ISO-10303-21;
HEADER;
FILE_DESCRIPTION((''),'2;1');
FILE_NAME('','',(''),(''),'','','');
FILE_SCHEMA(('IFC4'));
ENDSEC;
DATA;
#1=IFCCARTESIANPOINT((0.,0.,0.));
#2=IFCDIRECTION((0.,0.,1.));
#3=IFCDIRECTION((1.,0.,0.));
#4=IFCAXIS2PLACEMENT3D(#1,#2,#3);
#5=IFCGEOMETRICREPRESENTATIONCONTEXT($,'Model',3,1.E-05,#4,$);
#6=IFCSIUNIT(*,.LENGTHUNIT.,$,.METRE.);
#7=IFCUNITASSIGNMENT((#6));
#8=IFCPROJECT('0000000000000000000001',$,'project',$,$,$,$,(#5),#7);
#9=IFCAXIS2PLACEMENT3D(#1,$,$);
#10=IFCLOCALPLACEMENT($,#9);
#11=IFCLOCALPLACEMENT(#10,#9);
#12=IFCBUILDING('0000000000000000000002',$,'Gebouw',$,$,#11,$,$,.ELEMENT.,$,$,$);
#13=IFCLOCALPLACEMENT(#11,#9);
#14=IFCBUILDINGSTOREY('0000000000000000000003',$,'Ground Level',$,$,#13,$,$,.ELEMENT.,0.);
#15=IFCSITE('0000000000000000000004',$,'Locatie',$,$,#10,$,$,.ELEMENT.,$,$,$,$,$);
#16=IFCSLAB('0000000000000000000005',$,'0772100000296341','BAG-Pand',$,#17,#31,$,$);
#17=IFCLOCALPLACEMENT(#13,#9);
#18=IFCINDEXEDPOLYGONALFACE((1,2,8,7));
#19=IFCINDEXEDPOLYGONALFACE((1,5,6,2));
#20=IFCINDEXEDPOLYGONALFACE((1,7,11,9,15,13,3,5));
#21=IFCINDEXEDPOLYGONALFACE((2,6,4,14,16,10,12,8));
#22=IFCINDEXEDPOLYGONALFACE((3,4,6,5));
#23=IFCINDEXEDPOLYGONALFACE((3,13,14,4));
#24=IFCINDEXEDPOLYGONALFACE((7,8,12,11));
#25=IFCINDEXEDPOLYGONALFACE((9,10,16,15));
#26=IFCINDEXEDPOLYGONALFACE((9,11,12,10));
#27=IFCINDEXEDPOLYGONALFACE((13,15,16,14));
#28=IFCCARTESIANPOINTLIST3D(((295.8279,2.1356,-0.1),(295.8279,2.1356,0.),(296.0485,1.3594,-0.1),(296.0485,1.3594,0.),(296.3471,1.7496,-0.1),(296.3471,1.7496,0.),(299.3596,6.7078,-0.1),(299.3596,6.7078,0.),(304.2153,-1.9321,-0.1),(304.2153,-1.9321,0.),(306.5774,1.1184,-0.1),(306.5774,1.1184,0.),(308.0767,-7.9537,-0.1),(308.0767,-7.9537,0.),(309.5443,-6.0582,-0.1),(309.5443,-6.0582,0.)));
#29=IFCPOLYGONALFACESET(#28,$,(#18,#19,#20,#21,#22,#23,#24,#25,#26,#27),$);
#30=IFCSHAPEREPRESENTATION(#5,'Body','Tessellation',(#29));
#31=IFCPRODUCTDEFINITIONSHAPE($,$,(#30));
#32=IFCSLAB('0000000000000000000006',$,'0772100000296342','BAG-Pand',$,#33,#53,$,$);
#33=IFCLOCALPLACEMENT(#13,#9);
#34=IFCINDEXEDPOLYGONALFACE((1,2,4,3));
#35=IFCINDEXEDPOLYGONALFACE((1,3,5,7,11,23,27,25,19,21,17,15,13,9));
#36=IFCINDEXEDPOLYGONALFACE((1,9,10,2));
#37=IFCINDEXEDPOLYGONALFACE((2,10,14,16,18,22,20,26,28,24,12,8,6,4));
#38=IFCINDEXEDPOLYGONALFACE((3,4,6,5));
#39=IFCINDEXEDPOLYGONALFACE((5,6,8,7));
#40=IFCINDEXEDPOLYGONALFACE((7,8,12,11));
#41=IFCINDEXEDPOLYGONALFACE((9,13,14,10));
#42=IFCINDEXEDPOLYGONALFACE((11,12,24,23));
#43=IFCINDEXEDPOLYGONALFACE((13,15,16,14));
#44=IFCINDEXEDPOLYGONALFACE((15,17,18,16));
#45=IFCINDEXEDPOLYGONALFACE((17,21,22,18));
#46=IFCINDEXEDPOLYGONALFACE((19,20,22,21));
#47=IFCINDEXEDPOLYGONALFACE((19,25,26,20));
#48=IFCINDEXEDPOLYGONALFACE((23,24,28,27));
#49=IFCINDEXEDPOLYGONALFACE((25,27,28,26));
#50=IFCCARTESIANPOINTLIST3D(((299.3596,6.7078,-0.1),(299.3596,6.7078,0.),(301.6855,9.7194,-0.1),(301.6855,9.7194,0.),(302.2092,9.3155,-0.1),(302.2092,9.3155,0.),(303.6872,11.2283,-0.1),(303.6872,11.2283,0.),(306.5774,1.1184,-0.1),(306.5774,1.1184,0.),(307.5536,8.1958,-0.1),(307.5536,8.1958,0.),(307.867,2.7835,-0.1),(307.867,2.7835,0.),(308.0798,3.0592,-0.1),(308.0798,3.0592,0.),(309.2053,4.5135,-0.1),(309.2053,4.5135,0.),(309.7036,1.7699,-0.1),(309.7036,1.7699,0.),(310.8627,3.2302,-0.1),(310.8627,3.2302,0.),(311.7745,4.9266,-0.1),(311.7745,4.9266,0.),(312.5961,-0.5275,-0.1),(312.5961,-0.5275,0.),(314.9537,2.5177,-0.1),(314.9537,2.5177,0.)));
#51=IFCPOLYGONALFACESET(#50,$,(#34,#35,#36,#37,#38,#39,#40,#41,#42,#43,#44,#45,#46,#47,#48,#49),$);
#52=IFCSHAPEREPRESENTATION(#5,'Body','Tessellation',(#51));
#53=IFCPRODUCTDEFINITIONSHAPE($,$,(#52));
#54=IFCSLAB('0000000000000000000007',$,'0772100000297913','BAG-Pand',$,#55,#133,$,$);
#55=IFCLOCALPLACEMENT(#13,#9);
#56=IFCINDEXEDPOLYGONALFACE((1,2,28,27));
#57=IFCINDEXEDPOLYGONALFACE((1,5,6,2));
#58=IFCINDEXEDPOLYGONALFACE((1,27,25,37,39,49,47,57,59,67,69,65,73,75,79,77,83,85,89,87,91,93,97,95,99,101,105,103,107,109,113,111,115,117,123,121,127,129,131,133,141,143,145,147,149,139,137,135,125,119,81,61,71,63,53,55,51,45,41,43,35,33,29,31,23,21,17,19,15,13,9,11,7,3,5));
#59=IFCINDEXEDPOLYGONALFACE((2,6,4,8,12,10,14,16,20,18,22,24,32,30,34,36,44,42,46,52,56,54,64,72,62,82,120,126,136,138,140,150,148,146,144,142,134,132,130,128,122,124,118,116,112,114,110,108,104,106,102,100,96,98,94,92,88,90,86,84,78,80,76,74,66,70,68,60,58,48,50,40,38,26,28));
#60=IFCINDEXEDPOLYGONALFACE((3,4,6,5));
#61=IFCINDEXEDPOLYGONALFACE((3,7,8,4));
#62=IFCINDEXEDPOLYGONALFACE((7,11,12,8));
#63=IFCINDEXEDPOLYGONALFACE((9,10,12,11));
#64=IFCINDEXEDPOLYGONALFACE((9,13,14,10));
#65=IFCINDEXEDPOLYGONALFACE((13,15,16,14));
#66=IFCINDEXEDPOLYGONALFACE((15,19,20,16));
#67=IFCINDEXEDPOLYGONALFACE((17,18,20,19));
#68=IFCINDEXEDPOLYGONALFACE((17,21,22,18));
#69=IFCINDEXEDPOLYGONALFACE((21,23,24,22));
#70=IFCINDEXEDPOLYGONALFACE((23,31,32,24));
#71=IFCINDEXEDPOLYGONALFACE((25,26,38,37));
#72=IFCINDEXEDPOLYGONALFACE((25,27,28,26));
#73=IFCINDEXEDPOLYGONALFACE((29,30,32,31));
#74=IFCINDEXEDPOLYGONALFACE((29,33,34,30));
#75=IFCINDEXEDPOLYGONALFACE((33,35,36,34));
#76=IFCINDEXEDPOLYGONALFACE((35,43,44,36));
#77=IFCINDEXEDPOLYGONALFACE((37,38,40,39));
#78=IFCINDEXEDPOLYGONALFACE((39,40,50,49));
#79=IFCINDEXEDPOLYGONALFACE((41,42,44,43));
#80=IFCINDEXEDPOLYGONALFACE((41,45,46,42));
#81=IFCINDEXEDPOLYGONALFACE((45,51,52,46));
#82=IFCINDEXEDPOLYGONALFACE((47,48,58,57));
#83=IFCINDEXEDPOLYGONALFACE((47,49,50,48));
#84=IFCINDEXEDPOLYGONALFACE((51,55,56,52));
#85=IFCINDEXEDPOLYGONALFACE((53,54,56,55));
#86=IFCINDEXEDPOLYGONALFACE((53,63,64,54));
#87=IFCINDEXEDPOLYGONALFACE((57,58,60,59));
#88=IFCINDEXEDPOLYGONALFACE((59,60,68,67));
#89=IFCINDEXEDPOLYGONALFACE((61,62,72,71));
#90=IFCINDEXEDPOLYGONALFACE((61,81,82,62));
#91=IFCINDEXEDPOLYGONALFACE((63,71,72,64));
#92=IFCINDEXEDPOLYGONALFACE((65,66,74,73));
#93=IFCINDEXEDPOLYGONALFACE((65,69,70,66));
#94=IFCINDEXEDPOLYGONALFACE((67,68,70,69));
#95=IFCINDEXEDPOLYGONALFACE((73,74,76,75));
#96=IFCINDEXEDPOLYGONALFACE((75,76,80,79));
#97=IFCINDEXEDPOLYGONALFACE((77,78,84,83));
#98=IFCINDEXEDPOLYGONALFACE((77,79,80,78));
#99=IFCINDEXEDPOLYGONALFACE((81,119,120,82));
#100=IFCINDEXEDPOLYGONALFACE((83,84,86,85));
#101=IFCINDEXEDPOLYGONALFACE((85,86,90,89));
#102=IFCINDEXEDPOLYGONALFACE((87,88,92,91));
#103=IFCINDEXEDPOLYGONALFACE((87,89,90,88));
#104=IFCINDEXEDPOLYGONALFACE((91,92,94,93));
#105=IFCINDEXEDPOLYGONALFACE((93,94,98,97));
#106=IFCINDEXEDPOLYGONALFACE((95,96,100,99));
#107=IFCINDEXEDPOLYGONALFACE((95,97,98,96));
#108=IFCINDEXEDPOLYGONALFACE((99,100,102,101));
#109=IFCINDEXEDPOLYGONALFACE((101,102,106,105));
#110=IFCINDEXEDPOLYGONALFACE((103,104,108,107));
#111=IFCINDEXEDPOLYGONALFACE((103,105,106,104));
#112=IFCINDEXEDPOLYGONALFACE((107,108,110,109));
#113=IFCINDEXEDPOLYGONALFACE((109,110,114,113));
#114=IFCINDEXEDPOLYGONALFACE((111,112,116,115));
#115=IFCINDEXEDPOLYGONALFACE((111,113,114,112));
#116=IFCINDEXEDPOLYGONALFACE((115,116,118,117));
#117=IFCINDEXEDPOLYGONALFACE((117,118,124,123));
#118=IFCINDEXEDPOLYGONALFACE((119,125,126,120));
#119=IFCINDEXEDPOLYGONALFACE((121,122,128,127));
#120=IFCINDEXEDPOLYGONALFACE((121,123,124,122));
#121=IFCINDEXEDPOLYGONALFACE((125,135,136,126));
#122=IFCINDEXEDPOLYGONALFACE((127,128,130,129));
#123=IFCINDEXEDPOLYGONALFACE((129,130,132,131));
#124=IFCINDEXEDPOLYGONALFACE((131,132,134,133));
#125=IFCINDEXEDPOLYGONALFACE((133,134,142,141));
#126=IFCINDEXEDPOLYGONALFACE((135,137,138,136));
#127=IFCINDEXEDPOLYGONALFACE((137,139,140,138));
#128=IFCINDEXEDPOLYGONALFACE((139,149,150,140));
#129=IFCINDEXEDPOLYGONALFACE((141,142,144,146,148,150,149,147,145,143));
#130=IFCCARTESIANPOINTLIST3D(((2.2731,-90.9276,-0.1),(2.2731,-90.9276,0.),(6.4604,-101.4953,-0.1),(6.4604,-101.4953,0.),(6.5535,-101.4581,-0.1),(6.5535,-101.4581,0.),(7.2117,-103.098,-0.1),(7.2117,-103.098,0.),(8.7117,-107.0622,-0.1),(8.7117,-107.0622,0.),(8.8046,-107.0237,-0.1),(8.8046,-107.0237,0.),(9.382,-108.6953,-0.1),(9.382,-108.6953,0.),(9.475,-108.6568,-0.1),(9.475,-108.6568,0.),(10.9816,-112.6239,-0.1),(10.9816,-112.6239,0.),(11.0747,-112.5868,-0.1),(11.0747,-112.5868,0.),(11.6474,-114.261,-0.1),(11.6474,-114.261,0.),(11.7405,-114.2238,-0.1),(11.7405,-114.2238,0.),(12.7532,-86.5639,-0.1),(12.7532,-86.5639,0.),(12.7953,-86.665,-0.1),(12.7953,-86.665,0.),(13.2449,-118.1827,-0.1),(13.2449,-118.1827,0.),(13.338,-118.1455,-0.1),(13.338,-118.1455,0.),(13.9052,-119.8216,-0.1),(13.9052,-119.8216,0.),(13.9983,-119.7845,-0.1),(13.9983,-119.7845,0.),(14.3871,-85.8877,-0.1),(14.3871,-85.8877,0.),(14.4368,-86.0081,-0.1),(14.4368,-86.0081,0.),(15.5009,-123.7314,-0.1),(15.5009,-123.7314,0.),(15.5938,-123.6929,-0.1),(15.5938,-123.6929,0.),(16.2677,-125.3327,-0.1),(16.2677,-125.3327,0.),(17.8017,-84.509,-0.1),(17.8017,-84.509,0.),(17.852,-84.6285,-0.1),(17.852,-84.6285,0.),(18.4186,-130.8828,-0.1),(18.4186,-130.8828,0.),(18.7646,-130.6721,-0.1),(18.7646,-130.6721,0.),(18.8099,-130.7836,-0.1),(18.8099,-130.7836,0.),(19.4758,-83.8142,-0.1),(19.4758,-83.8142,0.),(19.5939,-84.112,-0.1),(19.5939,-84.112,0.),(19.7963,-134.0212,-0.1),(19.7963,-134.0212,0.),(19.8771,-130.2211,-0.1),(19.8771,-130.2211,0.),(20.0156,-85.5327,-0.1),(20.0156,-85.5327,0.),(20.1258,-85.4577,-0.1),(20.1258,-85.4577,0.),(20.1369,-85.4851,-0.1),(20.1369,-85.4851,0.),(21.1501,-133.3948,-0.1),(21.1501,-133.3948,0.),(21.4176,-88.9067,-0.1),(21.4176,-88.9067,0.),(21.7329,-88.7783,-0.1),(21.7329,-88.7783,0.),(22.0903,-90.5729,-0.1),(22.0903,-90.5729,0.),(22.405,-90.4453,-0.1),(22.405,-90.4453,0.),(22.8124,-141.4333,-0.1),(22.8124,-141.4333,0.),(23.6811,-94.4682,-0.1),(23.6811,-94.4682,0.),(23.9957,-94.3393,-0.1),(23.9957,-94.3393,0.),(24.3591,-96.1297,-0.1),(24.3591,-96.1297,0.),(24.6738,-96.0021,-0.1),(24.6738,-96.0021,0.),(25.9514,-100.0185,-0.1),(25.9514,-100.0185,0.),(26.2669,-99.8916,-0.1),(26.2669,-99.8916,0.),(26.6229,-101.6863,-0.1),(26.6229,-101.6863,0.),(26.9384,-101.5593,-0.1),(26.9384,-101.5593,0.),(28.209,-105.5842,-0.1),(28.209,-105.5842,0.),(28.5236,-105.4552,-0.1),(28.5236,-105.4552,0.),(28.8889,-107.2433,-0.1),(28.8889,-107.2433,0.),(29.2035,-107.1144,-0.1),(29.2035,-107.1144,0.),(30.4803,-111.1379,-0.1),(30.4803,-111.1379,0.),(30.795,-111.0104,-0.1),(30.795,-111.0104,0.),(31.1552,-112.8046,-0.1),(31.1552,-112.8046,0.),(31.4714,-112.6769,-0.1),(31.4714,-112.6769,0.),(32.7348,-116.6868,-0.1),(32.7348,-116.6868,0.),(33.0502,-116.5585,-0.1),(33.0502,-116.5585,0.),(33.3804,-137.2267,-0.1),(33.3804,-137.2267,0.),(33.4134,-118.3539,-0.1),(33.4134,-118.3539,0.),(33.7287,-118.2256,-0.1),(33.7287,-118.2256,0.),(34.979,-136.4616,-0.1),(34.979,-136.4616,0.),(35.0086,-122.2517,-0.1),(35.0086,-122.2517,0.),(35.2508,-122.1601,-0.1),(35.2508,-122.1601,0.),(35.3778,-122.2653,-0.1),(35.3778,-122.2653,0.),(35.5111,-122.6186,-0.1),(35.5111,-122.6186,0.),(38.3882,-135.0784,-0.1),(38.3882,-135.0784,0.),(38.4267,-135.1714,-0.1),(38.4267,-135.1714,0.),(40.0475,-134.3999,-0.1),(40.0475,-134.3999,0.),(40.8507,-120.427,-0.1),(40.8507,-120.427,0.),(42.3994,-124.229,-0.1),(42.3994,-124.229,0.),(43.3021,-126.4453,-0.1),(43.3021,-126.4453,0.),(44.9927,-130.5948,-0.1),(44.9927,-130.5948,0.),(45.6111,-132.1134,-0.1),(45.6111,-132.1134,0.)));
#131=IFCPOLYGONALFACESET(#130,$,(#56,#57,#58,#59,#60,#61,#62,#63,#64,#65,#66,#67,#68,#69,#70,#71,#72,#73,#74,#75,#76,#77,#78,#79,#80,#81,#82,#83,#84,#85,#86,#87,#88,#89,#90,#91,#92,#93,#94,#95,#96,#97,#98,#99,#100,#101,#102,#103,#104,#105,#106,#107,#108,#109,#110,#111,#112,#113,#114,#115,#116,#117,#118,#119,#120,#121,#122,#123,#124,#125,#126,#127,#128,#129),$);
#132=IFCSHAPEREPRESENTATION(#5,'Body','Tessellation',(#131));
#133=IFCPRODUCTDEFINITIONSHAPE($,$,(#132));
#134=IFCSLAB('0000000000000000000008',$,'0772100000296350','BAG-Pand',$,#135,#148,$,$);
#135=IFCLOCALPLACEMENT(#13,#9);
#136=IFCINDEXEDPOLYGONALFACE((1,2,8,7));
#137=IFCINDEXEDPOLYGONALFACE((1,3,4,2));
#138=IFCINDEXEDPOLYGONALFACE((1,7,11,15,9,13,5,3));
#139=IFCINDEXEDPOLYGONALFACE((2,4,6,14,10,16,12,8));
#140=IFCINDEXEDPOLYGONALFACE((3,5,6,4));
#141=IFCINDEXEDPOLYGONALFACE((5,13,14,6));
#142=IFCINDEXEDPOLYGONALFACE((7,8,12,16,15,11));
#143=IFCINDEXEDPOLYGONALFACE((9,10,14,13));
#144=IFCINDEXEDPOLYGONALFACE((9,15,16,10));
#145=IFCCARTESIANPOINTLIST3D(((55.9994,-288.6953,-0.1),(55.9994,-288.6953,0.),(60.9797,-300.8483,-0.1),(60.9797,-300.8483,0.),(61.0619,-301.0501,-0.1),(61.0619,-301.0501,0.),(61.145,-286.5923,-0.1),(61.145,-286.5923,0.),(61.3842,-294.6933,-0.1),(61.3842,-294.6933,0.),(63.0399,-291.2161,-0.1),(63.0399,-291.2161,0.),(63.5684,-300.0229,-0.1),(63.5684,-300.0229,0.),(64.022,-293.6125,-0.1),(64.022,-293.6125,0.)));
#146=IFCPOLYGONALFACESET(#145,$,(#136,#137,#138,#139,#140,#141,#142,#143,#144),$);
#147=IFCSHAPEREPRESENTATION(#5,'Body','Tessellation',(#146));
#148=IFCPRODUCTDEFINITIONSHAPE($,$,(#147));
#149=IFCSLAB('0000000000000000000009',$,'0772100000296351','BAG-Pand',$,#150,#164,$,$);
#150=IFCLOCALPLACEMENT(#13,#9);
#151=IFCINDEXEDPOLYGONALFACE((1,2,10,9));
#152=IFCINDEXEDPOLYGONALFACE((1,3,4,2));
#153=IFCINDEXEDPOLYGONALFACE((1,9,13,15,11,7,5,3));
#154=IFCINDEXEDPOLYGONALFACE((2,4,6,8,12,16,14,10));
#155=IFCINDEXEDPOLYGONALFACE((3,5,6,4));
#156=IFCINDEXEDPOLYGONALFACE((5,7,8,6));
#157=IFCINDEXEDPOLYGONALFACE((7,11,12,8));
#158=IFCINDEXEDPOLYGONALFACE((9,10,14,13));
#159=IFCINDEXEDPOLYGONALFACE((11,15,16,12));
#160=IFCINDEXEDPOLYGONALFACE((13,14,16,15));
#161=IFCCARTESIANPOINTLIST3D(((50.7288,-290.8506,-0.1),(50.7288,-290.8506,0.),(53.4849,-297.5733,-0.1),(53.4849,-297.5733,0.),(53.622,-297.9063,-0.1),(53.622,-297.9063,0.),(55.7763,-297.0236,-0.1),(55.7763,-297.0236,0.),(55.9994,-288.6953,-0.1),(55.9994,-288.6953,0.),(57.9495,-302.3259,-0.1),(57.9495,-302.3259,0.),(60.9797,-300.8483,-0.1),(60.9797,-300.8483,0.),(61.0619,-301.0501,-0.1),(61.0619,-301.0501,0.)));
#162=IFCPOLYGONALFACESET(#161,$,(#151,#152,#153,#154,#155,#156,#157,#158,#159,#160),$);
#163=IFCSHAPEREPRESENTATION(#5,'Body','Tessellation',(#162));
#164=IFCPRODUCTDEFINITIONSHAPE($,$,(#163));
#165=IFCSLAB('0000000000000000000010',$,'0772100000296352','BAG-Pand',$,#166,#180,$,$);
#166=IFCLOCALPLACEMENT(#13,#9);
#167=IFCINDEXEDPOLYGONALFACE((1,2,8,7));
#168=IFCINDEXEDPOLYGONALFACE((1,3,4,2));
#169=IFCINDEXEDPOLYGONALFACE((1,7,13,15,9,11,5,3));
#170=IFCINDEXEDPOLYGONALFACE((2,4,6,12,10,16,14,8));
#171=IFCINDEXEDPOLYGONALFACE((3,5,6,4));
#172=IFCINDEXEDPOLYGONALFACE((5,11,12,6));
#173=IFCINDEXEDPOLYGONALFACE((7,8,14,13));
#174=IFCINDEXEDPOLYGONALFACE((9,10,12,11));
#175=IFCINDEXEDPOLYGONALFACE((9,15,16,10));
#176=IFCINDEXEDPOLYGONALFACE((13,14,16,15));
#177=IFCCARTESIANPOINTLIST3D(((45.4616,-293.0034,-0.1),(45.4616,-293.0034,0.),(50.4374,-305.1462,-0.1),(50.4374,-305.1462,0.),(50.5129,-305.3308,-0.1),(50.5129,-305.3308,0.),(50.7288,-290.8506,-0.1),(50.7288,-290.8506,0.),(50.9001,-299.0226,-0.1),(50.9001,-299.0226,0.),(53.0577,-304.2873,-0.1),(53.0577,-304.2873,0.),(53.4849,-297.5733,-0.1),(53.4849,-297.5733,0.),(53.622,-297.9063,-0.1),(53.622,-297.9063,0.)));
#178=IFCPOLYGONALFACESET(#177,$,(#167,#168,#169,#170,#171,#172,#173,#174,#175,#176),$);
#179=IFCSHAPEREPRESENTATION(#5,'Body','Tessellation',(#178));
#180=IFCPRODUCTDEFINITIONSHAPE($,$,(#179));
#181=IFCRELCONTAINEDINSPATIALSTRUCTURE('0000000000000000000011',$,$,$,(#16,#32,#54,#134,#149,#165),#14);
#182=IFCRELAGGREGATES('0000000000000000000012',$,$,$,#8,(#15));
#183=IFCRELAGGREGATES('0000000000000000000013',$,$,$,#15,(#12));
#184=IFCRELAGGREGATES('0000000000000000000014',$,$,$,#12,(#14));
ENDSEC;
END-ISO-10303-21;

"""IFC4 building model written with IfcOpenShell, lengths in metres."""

from ifc_helpers import new_model, si_unit, frame, origin, origin_with_axes, place, context, project, spatial, polyline, outline, extrude, element, save


model = new_model("IFC4")

# Units and contexts
model_context = context("Model", 3, precision=1e-05, world=origin_with_axes())
ifc_project = project(units=[si_unit("LENGTHUNIT", "METRE")], contexts=[model_context])

# Site, building, storey
site_placement = place(None, origin())
site = spatial("IfcSite", under=ifc_project, at=site_placement, Name="Locatie", CompositionType="ELEMENT")
building_placement = place(site_placement, origin())
building = spatial("IfcBuilding", under=site, at=building_placement, Name="Gebouw", CompositionType="ELEMENT")
storey_placement = place(building_placement, origin())
storey = spatial("IfcBuildingStorey", under=building, at=storey_placement, Name="Ground Level", CompositionType="ELEMENT", Elevation=0.0)

# Slabs
slab_1_placement = place(storey_placement, origin())
element("IfcSlab", 1, at=slab_1_placement, inside=storey, Name="0772100000296341", Description="BAG-Pand", context=model_context, shape_type="SweptSolid", body=[
    extrude(outline(polyline([(296.3471, 1.7496), (295.8279, 2.1356), (299.3596, 6.7078), (306.5774, 1.1184), (304.2153, -1.9321), (309.5443, -6.0582), (308.0767, -7.9537), (296.0485, 1.3594), (296.3471, 1.7496)])), frame((0.0, 0.0, -0.1), z_axis=(0.0, 0.0, 1.0), x_axis=(1.0, 0.0, 0.0)), (0.0, 0.0, 1.0), 0.1),
])
slab_2_placement = place(storey_placement, origin())
element("IfcSlab", 2, at=slab_2_placement, inside=storey, Name="0772100000296342", Description="BAG-Pand", context=model_context, shape_type="SweptSolid", body=[
    extrude(outline(polyline([(301.6855, 9.7194), (302.2092, 9.3155), (303.6872, 11.2283), (307.5536, 8.1958), (311.7745, 4.9266), (314.9537, 2.5177), (312.5961, -0.5275), (309.7036, 1.7699), (310.8627, 3.2302), (309.2053, 4.5135), (308.0798, 3.0592), (307.867, 2.7835), (306.5774, 1.1184), (299.3596, 6.7078), (301.6855, 9.7194)])), frame((0.0, 0.0, -0.1), z_axis=(0.0, 0.0, 1.0), x_axis=(1.0, 0.0, 0.0)), (0.0, 0.0, 1.0), 0.1),
])
slab_3_placement = place(storey_placement, origin())
element("IfcSlab", 3, at=slab_3_placement, inside=storey, Name="0772100000297913", Description="BAG-Pand", context=model_context, shape_type="SweptSolid", body=[
    extrude(outline(polyline([(19.7963, -134.0212), (21.1501, -133.3948), (19.8771, -130.2211), (18.7646, -130.6721), (18.8099, -130.7836), (18.4186, -130.8828), (16.2677, -125.3327), (15.5009, -123.7314), (15.5938, -123.6929), (13.9983, -119.7845), (13.9052, -119.8216), (13.2449, -118.1827), (13.338, -118.1455), (11.7405, -114.2238), (11.6474, -114.261), (10.9816, -112.6239), (11.0747, -112.5868), (9.475, -108.6568), (9.382, -108.6953), (8.7117, -107.0622), (8.8046, -107.0237), (7.2117, -103.098), (6.4604, -101.4953), (6.5535, -101.4581), (2.2731, -90.9276), (12.7953, -86.665), (12.7532, -86.5639), (14.3871, -85.8877), (14.4368, -86.0081), (17.852, -84.6285), (17.8017, -84.509), (19.4758, -83.8142), (19.5939, -84.112), (20.1258, -85.4577), (20.1369, -85.4851), (20.0156, -85.5327), (21.4176, -88.9067), (21.7329, -88.7783), (22.405, -90.4453), (22.0903, -90.5729), (23.6811, -94.4682), (23.9957, -94.3393), (24.6738, -96.0021), (24.3591, -96.1297), (25.9514, -100.0185), (26.2669, -99.8916), (26.9384, -101.5593), (26.6229, -101.6863), (28.209, -105.5842), (28.5236, -105.4552), (29.2035, -107.1144), (28.8889, -107.2433), (30.4803, -111.1379), (30.795, -111.0104), (31.4714, -112.6769), (31.1552, -112.8046), (32.7348, -116.6868), (33.0502, -116.5585), (33.7287, -118.2256), (33.4134, -118.3539), (35.0086, -122.2517), (35.2508, -122.1601), (35.3778, -122.2653), (35.5111, -122.6186), (40.8507, -120.427), (42.3994, -124.229), (43.3021, -126.4453), (44.9927, -130.5948), (45.6111, -132.1134), (40.0475, -134.3999), (38.4267, -135.1714), (38.3882, -135.0784), (34.979, -136.4616), (33.3804, -137.2267), (22.8124, -141.4333), (19.7963, -134.0212)])), frame((0.0, 0.0, -0.1), z_axis=(0.0, 0.0, 1.0), x_axis=(1.0, 0.0, 0.0)), (0.0, 0.0, 1.0), 0.1),
])
slab_4_placement = place(storey_placement, origin())
element("IfcSlab", 4, at=slab_4_placement, inside=storey, Name="0772100000296350", Description="BAG-Pand", context=model_context, shape_type="SweptSolid", body=[
    extrude(outline(polyline([(61.0619, -301.0501), (60.9797, -300.8483), (55.9994, -288.6953), (61.145, -286.5923), (63.0399, -291.2161), (64.022, -293.6125), (61.3842, -294.6933), (63.5684, -300.0229), (61.0619, -301.0501)])), frame((0.0, 0.0, -0.1), z_axis=(0.0, 0.0, 1.0), x_axis=(1.0, 0.0, 0.0)), (0.0, 0.0, 1.0), 0.1),
])
slab_5_placement = place(storey_placement, origin())
element("IfcSlab", 5, at=slab_5_placement, inside=storey, Name="0772100000296351", Description="BAG-Pand", context=model_context, shape_type="SweptSolid", body=[
    extrude(outline(polyline([(53.622, -297.9063), (53.4849, -297.5733), (50.7288, -290.8506), (55.9994, -288.6953), (60.9797, -300.8483), (61.0619, -301.0501), (57.9495, -302.3259), (55.7763, -297.0236), (53.622, -297.9063)])), frame((0.0, 0.0, -0.1), z_axis=(0.0, 0.0, 1.0), x_axis=(1.0, 0.0, 0.0)), (0.0, 0.0, 1.0), 0.1),
])
slab_6_placement = place(storey_placement, origin())
element("IfcSlab", 6, at=slab_6_placement, inside=storey, Name="0772100000296352", Description="BAG-Pand", context=model_context, shape_type="SweptSolid", body=[
    extrude(outline(polyline([(50.5129, -305.3308), (50.4374, -305.1462), (45.4616, -293.0034), (50.7288, -290.8506), (53.4849, -297.5733), (53.622, -297.9063), (50.9001, -299.0226), (53.0577, -304.2873), (50.5129, -305.3308)])), frame((0.0, 0.0, -0.1), z_axis=(0.0, 0.0, 1.0), x_axis=(1.0, 0.0, 0.0)), (0.0, 0.0, 1.0), 0.1),
])

save(model, "model.ifc")
